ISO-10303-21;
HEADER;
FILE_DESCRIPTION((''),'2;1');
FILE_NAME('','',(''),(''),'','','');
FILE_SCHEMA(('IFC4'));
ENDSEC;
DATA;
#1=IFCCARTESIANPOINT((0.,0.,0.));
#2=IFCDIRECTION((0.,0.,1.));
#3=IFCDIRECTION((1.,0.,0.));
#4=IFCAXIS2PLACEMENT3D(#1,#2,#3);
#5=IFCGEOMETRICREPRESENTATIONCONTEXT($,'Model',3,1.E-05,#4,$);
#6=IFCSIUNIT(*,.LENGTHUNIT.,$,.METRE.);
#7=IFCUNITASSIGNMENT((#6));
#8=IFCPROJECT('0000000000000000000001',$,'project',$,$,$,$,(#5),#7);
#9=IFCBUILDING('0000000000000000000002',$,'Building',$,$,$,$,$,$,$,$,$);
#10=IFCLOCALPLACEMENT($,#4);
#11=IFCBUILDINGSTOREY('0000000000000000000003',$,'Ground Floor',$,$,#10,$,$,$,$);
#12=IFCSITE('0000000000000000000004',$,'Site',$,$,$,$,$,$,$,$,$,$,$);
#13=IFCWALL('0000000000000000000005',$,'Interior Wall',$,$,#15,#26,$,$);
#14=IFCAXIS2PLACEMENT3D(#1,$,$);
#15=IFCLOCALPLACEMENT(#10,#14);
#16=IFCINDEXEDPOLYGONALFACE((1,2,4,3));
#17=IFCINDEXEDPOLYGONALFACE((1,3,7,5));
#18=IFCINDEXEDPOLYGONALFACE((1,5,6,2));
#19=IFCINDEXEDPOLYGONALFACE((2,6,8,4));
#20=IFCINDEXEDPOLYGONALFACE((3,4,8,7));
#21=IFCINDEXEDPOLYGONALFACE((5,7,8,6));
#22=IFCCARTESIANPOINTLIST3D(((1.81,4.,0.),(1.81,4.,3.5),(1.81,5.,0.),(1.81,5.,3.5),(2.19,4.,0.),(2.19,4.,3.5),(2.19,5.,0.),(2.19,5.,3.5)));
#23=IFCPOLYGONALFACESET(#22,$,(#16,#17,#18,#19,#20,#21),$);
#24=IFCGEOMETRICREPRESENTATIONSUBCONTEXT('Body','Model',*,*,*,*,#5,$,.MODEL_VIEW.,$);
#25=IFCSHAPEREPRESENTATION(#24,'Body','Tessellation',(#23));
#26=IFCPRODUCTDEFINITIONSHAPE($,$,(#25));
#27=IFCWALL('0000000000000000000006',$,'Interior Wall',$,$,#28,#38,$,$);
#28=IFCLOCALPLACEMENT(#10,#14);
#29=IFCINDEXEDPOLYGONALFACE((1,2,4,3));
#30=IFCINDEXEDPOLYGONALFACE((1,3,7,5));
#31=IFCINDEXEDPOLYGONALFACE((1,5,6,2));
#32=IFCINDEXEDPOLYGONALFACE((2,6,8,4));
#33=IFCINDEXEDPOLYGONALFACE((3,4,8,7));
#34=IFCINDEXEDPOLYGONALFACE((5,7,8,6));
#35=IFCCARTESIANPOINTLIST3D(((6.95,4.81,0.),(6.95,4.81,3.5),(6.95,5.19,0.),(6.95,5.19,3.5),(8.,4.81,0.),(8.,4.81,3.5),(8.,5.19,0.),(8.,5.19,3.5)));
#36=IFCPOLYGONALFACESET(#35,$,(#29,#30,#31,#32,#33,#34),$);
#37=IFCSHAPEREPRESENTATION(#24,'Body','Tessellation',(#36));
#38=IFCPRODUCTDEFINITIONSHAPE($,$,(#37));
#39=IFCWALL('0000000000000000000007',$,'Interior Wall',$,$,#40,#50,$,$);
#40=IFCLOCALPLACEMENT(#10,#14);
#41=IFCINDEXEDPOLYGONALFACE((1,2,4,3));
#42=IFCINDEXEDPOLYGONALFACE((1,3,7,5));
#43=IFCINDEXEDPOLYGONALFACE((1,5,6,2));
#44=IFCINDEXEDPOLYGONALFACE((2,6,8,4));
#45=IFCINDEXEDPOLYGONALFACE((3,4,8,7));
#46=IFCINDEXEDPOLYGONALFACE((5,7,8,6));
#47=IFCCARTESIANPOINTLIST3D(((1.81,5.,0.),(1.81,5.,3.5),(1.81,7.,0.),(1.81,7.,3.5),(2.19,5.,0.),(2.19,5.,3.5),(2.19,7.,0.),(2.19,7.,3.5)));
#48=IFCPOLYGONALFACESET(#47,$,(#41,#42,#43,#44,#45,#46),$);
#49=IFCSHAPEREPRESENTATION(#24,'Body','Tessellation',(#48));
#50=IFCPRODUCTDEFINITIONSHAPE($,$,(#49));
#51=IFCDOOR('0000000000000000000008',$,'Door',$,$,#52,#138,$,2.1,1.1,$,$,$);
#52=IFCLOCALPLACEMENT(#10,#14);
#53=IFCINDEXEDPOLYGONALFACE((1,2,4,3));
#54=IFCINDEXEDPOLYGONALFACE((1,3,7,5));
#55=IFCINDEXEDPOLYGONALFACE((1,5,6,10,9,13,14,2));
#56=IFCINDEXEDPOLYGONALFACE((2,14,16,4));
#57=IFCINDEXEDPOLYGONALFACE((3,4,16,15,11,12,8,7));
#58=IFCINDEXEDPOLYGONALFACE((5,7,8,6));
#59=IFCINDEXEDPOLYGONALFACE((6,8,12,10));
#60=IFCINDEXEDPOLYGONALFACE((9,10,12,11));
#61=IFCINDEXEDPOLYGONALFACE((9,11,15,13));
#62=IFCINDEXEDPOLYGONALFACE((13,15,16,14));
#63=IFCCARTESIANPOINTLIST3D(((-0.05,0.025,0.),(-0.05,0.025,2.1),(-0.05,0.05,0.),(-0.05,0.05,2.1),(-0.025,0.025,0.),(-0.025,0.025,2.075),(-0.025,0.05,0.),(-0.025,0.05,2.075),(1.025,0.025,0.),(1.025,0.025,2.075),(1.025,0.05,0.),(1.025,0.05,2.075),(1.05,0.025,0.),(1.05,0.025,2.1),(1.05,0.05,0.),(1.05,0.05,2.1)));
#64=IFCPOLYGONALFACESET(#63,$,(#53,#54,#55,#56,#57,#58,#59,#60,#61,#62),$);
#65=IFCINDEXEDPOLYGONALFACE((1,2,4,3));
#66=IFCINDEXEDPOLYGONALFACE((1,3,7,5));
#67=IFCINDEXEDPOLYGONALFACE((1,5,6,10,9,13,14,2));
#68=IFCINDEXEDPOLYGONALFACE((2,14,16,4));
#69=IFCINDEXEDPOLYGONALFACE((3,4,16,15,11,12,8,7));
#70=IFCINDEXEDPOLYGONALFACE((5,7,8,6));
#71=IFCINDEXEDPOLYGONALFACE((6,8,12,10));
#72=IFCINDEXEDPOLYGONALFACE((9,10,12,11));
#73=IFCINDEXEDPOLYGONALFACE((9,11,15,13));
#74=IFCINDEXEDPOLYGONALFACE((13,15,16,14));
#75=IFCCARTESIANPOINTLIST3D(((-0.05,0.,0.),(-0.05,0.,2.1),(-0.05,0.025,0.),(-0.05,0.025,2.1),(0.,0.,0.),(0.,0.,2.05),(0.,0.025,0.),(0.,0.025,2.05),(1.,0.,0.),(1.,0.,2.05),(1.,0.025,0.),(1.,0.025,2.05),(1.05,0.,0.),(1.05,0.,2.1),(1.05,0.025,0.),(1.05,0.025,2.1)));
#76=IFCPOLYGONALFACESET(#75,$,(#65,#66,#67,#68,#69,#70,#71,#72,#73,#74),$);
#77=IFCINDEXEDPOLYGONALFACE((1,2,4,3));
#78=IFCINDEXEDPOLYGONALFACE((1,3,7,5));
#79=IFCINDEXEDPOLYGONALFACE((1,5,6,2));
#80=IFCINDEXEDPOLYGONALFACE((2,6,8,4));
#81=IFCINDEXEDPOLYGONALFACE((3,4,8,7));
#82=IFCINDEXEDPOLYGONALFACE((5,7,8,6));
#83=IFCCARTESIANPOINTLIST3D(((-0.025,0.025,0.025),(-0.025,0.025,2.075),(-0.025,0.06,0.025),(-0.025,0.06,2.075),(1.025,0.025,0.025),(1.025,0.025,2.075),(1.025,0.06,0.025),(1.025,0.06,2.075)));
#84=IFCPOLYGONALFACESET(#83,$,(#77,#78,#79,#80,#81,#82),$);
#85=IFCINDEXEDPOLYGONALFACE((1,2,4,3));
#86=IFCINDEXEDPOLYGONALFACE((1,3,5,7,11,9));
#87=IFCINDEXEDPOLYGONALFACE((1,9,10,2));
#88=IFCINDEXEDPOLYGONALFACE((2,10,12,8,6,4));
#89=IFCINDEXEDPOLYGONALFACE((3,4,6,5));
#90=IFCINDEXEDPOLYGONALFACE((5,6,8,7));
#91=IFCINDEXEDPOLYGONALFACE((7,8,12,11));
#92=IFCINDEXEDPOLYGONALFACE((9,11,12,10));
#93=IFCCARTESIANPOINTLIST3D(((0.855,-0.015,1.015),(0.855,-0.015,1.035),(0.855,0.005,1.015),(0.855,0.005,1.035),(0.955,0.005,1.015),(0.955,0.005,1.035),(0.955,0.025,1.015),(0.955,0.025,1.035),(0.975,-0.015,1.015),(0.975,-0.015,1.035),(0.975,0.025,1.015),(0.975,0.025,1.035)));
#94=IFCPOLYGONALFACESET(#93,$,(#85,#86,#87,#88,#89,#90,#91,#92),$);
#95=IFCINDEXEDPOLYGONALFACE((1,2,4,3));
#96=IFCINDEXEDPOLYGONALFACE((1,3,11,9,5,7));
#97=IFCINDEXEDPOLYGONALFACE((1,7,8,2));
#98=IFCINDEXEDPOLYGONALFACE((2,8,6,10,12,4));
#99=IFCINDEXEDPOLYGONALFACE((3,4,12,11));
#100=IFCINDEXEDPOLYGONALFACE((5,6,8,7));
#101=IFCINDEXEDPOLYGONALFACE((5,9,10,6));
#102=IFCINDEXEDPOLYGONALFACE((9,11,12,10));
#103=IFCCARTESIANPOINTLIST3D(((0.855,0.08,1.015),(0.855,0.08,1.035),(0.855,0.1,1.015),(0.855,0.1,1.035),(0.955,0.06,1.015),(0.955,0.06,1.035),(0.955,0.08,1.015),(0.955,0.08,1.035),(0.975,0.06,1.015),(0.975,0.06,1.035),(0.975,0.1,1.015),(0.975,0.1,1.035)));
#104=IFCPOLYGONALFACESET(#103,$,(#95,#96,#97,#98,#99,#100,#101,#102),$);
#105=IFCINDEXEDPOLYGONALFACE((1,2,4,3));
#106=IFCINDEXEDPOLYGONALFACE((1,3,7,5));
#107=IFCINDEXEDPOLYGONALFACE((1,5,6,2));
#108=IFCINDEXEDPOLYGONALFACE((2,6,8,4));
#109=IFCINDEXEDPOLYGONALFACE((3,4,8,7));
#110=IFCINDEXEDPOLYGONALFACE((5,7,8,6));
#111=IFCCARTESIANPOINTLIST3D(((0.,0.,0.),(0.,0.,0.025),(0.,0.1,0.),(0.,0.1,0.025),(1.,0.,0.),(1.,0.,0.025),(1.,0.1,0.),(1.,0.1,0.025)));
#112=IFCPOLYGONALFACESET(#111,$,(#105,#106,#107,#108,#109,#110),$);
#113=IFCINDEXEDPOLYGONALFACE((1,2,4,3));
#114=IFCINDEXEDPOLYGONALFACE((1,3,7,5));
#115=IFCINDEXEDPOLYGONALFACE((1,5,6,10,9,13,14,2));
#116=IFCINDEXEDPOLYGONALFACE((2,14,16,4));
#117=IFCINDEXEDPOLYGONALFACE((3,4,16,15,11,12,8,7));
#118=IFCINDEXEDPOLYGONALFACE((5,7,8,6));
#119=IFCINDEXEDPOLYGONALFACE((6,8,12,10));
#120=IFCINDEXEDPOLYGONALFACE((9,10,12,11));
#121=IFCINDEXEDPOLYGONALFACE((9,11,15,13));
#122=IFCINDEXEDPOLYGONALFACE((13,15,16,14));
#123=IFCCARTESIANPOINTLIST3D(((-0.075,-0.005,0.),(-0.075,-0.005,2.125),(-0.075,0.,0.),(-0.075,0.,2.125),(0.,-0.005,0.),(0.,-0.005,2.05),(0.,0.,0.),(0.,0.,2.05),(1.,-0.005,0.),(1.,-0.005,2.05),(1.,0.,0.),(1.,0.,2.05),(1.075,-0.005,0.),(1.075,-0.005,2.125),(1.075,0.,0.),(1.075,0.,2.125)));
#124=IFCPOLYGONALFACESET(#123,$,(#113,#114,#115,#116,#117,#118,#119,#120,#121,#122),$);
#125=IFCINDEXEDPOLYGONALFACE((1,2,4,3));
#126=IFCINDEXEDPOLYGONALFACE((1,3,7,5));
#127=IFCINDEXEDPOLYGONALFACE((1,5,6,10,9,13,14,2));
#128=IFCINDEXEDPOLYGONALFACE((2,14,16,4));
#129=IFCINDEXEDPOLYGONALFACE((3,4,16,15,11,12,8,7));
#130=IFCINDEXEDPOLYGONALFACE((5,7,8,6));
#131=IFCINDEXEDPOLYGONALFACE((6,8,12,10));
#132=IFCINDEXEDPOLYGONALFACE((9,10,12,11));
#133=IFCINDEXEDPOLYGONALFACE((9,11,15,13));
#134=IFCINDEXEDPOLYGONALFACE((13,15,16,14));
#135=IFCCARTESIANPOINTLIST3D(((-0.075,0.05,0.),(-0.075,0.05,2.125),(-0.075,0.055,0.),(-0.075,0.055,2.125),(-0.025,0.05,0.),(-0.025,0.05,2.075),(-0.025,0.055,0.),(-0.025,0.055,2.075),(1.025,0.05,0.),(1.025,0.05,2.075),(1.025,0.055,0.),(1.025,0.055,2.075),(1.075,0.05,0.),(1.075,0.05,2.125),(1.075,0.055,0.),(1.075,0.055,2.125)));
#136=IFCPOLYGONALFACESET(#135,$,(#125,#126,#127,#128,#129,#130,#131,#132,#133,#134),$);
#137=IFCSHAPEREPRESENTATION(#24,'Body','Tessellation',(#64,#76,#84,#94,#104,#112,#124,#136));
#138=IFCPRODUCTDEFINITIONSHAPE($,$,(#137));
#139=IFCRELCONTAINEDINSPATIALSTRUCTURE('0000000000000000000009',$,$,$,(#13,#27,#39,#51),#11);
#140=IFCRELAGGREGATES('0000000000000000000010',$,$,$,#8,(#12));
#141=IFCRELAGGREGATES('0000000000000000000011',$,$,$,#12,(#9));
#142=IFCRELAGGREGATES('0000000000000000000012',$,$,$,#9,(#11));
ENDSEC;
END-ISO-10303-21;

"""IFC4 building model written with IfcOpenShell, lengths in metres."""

from ifc_helpers import new_model, si_unit, frame, origin_with_axes, place, context, subcontext, project, spatial, line, indexed_curve, outline, extrude, element, save


model = new_model("IFC4")

# Units and contexts
model_context = context("Model", 3, precision=1e-05, world=origin_with_axes())
body_context = subcontext(model_context, "Body", "Model", "MODEL_VIEW")
ifc_project = project(units=[si_unit("LENGTHUNIT", "METRE")], contexts=[model_context])

# Site, building, storey
site = spatial("IfcSite", under=ifc_project, Name="Site")
building = spatial("IfcBuilding", under=site, Name="Building")
storey_placement = place(None, origin_with_axes())
storey = spatial("IfcBuildingStorey", under=building, at=storey_placement, Name="Ground Floor")

# Walls
for number, where, z_axis, x_axis, name in (
    (1, (2.0, 5.0, 0.0), (0.0, 0.0, 1.0), (0.0, -1.0, 0.0), "Interior Wall"),
):
    element("IfcWall", number, at=place(storey_placement, frame(where, z_axis=z_axis, x_axis=x_axis)), inside=storey, Name=name, context=body_context, shape_type="SweptSolid", body=[
        extrude(outline(indexed_curve([(0.0, 0.0), (0.0, 0.38), (1.0, 0.38), (1.0, 0.0), (0.0, 0.0)], self_intersect=False)), frame((0.0, -0.19, 0.0), z_axis=(0.0, 0.0, 1.0), x_axis=(1.0, 0.0, 0.0)), (0.0, 0.0, 1.0), 3.5),
    ])
wall_1_placement = place(storey_placement, frame((8.0, 5.0, 0.0), z_axis=(0.0, 0.0, 1.0), x_axis=(-1.0, 0.0, 0.0)))
element("IfcWall", 2, at=wall_1_placement, inside=storey, Name="Interior Wall", context=body_context, shape_type="SweptSolid", body=[
    extrude(outline(indexed_curve([(0.0, 0.0), (0.0, 0.38), (1.05, 0.38), (1.05, 0.0), (0.0, 0.0)], self_intersect=False)), frame((0.0, -0.19, 0.0), z_axis=(0.0, 0.0, 1.0), x_axis=(1.0, 0.0, 0.0)), (0.0, 0.0, 1.0), 3.5),
])
wall_2_placement = place(storey_placement, frame((2.0, 5.0, 0.0), z_axis=(0.0, 0.0, 1.0), x_axis=(0.0, 1.0, 0.0)))
element("IfcWall", 3, at=wall_2_placement, inside=storey, Name="Interior Wall", context=body_context, shape_type="SweptSolid", body=[
    extrude(outline(indexed_curve([(0.0, 0.0), (0.0, 0.38), (2.0, 0.38), (2.0, 0.0), (0.0, 0.0)], self_intersect=False)), frame((0.0, -0.19, 0.0), z_axis=(0.0, 0.0, 1.0), x_axis=(1.0, 0.0, 0.0)), (0.0, 0.0, 1.0), 3.5),
])

# Door
door_1_placement = place(storey_placement, frame((-0.05, 0.0, 0.0), z_axis=(0.0, 0.0, 1.0), x_axis=(1.0, 0.0, 0.0)))
element("IfcDoor", 4, at=door_1_placement, inside=storey, Name="Door", OverallHeight=2.1, OverallWidth=1.1, context=body_context, shape_type="SweptSolid", body=[
    extrude(outline(indexed_curve([(0.0, 0.0), (0.0, 2.1), (1.1, 2.1), (1.1, 0.0), (1.075, 0.0), (1.075, 2.075), (0.025, 2.075), (0.025, 0.0)], segments=[line(1, 2, 3, 4, 5, 6, 7, 8, 1)])), frame((0.0, 0.025, 0.0), z_axis=(0.0, -1.0, 0.0), x_axis=(1.0, 0.0, 0.0)), (0.0, 0.0, -1.0), 0.025),
    extrude(outline(indexed_curve([(0.0, 0.0), (0.0, 2.1), (1.1, 2.1), (1.1, 0.0), (1.05, 0.0), (1.05, 2.05), (0.05, 2.05), (0.05, 0.0)], segments=[line(1, 2, 3, 4, 5, 6, 7, 8, 1)])), frame((0.0, 0.0, 0.0), z_axis=(0.0, -1.0, 0.0), x_axis=(1.0, 0.0, 0.0)), (0.0, 0.0, -1.0), 0.025),
    extrude(outline(indexed_curve([(0.0, 0.0), (1.05, 0.0), (1.05, 0.035), (0.0, 0.035)], segments=[line(1, 2, 3, 4, 1)])), frame((0.025, 0.025, 0.025), z_axis=(0.0, 0.0, 1.0), x_axis=(1.0, 0.0, 0.0)), (0.0, 0.0, 1.0), 2.05),
    extrude(outline(indexed_curve([(0.0, 0.0), (0.0, -0.04), (-0.12, -0.04), (-0.12, -0.02), (-0.02, -0.02), (-0.02, 0.0)], segments=[line(1, 2, 3, 4, 5, 6, 1)])), frame((1.025, 0.025, 1.015), z_axis=(0.0, 0.0, 1.0), x_axis=(1.0, 0.0, 0.0)), (0.0, 0.0, 1.0), 0.02),
    extrude(outline(indexed_curve([(0.0, 0.0), (0.0, 0.04), (-0.12, 0.04), (-0.12, 0.02), (-0.02, 0.02), (-0.02, 0.0)], segments=[line(1, 2, 3, 4, 5, 6, 1)])), frame((1.025, 0.06, 1.015), z_axis=(0.0, 0.0, 1.0), x_axis=(1.0, 0.0, 0.0)), (0.0, 0.0, 1.0), 0.02),
    extrude(outline(indexed_curve([(0.0, 0.0), (1.0, 0.0), (1.0, 0.1), (0.0, 0.1)], segments=[line(1, 2, 3, 4, 1)])), frame((0.05, 0.0, 0.0), z_axis=(0.0, 0.0, 1.0), x_axis=(1.0, 0.0, 0.0)), (0.0, 0.0, 1.0), 0.025),
    extrude(outline(indexed_curve([(0.0, 0.0), (0.0, 2.125), (1.15, 2.125), (1.15, 0.0), (1.075, 0.0), (1.075, 2.05), (0.075, 2.05), (0.075, 0.0)], segments=[line(1, 2, 3, 4, 5, 6, 7, 8, 1)])), frame((-0.025, -0.005, 0.0), z_axis=(0.0, -1.0, 0.0), x_axis=(1.0, 0.0, 0.0)), (0.0, 0.0, -1.0), 0.005),
    extrude(outline(indexed_curve([(0.0, 0.0), (0.0, 2.125), (1.15, 2.125), (1.15, 0.0), (1.1, 0.0), (1.1, 2.075), (0.05, 2.075), (0.05, 0.0)], segments=[line(1, 2, 3, 4, 5, 6, 7, 8, 1)])), frame((-0.025, 0.05, 0.0), z_axis=(0.0, -1.0, 0.0), x_axis=(1.0, 0.0, 0.0)), (0.0, 0.0, -1.0), 0.005),
])

save(model, "model.ifc")
